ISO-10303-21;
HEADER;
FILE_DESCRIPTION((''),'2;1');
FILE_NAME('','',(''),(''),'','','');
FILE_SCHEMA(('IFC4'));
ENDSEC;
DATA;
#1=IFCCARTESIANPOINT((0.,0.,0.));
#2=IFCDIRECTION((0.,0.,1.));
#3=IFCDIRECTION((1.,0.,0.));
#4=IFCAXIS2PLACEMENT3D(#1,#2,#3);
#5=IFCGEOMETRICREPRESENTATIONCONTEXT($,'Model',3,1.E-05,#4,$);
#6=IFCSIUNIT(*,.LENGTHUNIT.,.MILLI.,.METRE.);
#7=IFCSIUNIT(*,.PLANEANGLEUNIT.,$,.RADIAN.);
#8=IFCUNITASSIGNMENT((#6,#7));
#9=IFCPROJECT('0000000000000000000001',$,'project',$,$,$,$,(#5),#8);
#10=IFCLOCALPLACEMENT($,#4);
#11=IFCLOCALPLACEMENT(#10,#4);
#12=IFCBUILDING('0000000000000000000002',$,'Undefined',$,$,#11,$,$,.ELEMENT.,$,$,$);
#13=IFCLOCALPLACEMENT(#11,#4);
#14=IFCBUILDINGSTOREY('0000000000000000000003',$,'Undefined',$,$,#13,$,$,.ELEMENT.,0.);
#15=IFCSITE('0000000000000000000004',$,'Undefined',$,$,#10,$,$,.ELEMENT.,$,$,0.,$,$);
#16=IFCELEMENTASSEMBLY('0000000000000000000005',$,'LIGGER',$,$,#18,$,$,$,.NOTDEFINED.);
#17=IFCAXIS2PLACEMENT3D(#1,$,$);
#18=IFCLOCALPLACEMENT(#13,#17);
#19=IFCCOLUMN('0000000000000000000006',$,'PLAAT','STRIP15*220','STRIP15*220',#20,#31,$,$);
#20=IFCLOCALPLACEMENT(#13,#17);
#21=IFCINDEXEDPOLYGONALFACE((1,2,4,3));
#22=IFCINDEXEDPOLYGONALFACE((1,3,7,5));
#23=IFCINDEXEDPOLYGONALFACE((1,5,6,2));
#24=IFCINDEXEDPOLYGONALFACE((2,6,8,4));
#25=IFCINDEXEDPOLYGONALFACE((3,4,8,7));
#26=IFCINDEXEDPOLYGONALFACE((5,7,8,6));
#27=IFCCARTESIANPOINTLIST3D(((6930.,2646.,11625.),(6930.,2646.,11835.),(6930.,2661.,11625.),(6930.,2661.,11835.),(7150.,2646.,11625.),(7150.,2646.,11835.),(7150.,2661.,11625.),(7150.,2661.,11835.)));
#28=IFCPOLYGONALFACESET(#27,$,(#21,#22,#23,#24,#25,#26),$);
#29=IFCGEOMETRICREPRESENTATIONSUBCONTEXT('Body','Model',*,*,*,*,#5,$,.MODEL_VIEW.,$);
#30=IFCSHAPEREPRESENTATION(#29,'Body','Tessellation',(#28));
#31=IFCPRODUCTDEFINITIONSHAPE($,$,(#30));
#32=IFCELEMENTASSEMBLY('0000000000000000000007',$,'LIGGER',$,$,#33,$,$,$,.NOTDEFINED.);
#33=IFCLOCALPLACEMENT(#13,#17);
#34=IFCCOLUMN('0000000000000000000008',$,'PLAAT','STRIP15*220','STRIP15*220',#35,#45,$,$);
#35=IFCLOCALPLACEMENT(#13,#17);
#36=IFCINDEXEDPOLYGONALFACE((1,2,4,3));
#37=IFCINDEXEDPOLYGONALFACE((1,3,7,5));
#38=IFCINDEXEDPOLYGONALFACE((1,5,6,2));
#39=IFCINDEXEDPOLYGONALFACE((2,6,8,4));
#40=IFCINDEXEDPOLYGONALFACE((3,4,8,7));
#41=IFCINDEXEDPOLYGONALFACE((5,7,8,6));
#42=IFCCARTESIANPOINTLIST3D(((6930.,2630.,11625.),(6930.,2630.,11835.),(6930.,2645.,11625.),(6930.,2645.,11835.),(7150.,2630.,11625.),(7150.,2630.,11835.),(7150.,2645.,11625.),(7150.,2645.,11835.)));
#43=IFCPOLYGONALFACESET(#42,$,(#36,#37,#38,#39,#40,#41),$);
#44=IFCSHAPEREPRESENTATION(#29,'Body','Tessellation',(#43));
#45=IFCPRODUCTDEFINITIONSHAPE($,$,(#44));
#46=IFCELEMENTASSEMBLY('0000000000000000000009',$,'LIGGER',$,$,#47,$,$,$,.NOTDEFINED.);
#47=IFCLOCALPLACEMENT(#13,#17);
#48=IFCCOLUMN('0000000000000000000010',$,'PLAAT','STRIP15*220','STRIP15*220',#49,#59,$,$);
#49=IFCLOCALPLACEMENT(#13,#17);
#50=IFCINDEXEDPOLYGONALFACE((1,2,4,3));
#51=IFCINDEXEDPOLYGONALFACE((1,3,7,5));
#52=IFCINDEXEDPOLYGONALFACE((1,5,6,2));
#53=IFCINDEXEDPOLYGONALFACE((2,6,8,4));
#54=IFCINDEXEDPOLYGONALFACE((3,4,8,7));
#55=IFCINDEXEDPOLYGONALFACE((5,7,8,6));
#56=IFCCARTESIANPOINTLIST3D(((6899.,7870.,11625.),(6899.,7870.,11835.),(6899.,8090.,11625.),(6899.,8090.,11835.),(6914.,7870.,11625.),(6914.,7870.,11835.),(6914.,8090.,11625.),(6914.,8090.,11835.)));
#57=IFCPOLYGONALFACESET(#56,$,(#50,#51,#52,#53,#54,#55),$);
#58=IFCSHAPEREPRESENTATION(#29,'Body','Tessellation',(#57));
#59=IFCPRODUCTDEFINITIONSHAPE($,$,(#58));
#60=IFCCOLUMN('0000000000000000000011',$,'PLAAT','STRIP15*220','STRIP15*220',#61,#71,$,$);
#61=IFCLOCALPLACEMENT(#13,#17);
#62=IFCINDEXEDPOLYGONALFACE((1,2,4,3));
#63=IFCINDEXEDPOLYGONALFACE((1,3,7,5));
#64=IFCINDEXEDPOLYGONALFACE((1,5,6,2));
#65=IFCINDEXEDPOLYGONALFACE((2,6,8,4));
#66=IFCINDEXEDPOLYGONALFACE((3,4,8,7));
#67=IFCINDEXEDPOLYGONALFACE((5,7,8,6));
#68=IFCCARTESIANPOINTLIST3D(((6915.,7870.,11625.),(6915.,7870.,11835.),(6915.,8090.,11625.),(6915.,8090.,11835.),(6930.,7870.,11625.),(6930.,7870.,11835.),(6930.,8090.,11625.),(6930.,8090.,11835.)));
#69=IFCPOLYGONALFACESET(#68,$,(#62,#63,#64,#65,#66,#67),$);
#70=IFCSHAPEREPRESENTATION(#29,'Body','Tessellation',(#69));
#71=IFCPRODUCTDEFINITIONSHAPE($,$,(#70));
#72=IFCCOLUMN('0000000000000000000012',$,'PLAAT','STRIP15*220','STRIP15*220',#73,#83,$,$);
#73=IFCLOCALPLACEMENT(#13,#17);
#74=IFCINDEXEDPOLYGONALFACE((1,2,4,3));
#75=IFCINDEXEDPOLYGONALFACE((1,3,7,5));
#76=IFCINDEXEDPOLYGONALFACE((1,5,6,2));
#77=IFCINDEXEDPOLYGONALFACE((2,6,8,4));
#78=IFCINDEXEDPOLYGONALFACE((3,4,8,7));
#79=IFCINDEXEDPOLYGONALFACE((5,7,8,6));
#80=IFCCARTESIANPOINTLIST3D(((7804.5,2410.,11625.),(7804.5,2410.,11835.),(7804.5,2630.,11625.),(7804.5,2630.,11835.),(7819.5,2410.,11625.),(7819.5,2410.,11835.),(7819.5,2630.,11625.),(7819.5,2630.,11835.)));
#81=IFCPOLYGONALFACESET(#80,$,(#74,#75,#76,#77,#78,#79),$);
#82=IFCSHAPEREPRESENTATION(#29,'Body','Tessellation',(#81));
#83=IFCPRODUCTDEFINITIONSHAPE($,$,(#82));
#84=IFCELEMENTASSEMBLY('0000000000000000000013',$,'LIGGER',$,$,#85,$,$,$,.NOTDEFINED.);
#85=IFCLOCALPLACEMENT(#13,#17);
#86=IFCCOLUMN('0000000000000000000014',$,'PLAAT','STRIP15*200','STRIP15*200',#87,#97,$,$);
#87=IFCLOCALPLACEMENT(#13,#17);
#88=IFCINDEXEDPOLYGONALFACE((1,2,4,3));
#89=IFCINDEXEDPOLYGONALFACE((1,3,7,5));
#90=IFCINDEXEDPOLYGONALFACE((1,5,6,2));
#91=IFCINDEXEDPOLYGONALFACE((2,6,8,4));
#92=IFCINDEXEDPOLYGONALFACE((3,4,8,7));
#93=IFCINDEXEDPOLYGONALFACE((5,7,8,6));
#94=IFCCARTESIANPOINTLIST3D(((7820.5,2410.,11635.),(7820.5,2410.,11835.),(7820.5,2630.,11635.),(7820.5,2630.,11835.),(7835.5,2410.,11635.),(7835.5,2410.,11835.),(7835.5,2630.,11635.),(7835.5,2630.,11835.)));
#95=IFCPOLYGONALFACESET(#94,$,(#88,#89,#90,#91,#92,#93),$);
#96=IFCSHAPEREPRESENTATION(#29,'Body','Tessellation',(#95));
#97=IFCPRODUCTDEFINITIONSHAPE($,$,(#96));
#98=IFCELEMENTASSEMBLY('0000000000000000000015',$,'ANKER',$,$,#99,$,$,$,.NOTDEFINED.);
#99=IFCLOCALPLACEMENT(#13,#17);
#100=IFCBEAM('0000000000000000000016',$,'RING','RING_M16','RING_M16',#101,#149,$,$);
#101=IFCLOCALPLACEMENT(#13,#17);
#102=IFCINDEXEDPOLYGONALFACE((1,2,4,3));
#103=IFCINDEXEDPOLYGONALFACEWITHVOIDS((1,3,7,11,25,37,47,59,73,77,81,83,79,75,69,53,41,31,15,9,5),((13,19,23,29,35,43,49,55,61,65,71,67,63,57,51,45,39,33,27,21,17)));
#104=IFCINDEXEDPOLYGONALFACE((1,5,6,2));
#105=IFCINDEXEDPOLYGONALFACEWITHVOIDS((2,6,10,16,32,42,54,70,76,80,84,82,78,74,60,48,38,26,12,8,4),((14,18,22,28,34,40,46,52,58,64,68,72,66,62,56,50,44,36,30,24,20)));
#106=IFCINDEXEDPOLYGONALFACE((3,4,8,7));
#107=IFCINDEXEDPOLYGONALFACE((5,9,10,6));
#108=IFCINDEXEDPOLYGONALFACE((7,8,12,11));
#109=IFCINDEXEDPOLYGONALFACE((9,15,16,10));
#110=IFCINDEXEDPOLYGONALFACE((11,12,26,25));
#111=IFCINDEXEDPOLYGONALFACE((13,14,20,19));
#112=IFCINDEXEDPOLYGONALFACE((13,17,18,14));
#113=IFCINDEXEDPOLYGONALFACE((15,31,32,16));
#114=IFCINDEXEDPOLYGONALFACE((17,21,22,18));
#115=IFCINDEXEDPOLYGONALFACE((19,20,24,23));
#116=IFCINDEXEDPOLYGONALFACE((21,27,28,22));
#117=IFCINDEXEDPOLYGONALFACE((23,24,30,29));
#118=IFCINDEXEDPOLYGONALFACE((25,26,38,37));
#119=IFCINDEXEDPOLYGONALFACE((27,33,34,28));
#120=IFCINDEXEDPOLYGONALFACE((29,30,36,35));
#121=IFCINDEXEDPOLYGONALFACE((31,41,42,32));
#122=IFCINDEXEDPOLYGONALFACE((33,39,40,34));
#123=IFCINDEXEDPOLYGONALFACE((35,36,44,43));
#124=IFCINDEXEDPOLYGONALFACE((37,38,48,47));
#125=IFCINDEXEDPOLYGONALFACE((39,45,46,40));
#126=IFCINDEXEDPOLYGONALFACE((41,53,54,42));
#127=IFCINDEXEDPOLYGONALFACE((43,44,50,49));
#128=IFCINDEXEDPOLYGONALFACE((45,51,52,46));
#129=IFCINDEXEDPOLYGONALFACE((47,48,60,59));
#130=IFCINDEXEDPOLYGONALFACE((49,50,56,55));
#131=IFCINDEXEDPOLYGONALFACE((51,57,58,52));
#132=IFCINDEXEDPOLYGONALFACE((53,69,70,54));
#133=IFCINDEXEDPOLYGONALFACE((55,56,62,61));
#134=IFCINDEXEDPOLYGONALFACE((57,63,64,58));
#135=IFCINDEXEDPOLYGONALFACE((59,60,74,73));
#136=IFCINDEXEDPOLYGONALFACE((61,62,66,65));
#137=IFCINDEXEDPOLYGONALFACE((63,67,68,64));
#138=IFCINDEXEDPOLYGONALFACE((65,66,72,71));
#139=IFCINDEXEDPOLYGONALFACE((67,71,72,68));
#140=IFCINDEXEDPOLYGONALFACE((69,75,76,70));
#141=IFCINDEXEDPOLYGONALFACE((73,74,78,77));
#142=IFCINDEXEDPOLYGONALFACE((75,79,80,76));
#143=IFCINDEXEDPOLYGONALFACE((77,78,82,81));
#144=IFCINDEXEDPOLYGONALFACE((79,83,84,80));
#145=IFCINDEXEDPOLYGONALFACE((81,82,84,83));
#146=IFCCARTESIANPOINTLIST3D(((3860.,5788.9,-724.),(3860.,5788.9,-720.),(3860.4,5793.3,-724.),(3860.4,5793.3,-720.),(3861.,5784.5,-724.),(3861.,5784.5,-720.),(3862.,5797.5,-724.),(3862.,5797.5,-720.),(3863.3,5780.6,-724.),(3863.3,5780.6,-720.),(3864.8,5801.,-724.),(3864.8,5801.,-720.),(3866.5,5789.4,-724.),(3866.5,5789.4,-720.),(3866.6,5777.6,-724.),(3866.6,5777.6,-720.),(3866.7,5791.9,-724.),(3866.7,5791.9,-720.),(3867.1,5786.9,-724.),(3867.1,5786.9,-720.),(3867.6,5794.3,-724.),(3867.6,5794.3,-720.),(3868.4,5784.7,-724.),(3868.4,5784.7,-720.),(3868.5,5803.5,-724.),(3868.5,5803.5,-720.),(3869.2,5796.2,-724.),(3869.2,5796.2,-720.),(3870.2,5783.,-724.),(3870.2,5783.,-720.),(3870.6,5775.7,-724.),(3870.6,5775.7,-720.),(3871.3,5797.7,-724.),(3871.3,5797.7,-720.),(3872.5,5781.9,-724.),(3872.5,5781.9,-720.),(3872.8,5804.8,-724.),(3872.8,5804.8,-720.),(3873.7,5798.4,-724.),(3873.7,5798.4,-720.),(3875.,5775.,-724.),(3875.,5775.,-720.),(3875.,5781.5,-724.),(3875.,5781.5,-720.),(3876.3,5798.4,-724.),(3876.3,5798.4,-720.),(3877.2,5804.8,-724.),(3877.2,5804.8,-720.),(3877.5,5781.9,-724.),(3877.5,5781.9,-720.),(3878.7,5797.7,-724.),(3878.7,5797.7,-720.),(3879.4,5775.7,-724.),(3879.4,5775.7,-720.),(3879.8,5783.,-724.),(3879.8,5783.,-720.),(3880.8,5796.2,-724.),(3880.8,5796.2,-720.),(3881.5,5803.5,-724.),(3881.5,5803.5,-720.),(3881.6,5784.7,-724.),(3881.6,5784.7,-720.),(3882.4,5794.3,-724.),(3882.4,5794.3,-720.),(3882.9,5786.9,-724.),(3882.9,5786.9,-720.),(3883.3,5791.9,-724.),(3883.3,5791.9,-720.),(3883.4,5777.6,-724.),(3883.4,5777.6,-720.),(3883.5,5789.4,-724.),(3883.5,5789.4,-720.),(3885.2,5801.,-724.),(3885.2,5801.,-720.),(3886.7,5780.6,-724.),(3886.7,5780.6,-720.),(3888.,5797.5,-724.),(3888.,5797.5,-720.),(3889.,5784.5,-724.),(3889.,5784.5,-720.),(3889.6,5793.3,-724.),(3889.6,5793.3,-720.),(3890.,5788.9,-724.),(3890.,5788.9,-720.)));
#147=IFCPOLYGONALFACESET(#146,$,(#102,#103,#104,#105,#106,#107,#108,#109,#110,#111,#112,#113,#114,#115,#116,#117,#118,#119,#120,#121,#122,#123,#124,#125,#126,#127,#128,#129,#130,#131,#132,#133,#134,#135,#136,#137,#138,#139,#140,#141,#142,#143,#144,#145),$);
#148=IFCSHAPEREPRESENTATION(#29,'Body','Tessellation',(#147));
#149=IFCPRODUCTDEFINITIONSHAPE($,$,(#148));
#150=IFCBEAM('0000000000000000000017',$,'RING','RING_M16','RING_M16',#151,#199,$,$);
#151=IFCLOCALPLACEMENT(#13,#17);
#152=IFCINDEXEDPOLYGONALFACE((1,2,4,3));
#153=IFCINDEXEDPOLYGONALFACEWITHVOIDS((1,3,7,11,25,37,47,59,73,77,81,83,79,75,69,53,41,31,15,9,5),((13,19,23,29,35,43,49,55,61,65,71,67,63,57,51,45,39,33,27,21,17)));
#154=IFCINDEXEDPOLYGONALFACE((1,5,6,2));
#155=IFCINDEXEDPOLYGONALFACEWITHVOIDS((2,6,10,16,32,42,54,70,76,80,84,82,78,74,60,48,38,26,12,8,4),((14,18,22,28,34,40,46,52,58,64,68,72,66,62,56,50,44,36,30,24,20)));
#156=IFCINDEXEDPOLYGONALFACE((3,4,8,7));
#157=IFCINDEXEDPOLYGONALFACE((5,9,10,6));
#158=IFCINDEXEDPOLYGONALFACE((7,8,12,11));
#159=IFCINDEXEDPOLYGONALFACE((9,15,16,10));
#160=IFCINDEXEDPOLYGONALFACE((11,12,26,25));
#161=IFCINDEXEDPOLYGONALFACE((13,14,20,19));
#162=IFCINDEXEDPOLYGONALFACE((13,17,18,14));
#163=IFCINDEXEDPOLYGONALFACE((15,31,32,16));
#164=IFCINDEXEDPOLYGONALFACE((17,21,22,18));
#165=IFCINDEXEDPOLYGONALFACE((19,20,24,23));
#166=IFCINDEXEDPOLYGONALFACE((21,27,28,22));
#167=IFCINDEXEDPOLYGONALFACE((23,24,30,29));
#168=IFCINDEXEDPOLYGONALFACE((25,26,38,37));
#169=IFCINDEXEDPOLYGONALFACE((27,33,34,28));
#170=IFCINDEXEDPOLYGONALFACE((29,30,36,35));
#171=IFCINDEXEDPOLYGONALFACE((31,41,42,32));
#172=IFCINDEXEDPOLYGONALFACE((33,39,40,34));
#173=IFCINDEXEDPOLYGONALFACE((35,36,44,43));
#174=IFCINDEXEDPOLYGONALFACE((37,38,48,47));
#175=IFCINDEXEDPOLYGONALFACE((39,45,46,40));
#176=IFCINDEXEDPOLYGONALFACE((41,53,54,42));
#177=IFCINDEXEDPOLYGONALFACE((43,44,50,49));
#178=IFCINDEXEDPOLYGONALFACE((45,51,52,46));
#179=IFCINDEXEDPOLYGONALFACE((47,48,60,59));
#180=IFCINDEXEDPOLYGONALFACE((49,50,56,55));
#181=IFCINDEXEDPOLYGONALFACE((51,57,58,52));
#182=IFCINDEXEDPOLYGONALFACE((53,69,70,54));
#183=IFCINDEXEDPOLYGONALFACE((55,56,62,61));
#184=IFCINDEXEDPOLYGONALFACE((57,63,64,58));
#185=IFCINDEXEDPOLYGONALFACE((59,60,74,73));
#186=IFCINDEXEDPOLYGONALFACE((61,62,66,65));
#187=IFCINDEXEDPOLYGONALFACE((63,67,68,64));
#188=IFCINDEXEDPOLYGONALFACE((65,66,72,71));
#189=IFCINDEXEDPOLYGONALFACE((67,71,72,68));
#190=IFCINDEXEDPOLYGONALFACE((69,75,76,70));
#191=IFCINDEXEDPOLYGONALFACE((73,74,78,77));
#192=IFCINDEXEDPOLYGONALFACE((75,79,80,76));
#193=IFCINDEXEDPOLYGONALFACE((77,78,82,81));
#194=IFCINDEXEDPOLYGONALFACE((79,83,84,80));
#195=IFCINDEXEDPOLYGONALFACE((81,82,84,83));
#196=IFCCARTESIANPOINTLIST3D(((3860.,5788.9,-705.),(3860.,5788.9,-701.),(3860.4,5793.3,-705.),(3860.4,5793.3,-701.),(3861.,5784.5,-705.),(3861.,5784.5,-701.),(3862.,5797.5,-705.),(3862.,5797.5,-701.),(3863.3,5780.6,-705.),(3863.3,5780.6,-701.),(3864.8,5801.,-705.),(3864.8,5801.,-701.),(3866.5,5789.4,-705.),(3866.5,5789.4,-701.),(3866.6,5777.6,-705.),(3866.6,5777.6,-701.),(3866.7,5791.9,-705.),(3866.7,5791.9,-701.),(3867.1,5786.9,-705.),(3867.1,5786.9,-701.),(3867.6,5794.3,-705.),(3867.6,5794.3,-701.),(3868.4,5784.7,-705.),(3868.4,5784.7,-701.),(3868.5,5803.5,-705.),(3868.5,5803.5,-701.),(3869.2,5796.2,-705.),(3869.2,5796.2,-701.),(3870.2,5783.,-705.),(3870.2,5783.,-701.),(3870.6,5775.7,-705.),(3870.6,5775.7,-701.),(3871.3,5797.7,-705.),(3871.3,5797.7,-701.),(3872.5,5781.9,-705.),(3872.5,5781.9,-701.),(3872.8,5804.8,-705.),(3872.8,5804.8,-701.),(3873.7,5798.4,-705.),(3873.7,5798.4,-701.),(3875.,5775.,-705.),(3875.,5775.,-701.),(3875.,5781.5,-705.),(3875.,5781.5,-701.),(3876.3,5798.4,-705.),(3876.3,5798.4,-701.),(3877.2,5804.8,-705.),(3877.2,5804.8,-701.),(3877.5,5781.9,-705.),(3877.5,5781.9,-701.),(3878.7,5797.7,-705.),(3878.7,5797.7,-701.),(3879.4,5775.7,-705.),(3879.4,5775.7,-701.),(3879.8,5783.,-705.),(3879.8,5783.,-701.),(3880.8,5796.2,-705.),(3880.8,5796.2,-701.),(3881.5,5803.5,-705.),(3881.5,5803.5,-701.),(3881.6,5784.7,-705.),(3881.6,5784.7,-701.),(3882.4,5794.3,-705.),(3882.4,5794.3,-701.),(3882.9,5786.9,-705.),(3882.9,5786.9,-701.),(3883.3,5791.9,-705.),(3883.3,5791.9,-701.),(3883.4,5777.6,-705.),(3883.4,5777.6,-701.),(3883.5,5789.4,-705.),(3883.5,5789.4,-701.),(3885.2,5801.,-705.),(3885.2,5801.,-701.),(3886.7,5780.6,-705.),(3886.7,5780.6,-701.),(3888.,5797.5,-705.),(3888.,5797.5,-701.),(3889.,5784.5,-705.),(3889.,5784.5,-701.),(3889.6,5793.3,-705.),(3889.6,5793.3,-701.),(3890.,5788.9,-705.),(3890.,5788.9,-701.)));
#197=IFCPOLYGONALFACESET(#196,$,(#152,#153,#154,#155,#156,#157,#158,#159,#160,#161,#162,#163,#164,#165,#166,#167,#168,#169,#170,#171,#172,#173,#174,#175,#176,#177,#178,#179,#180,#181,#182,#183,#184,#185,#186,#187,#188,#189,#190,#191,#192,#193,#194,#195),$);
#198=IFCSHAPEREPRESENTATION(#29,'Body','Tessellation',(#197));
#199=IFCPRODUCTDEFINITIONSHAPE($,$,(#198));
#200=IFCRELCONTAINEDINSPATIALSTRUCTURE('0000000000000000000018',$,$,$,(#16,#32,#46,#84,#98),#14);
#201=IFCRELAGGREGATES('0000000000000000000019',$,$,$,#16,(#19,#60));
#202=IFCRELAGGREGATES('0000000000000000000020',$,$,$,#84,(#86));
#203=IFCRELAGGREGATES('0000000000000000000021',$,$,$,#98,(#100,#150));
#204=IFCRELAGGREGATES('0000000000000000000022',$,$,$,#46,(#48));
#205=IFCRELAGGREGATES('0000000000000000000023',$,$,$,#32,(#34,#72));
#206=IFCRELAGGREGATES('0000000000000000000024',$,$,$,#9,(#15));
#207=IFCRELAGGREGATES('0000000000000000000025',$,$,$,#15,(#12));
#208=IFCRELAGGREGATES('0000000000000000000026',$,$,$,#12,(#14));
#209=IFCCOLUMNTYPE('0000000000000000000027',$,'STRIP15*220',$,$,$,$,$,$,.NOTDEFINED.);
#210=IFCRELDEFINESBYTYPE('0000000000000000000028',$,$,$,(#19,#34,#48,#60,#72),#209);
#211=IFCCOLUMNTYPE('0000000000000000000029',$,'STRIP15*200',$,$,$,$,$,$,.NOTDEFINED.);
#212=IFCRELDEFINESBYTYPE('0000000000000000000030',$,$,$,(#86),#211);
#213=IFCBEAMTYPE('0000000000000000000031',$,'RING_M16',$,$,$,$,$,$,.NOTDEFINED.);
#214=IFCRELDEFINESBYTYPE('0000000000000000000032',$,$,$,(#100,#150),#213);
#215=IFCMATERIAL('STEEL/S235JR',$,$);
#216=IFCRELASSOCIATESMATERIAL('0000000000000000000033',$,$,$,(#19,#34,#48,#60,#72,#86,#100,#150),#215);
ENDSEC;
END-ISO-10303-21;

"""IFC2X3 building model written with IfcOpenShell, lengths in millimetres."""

from ifc_helpers import new_model, si_unit, frame, origin_with_axes, origin_2d_with_axis, place, context, subcontext, project, spatial, rectangle, hollow_circle, extrude, material, type_object, element, aggregate, save


model = new_model("IFC2X3")

# Units and contexts
model_context = context("Model", 3, precision=1e-05, world=origin_with_axes())
body_context = subcontext(model_context, "Body", "Model", "MODEL_VIEW")
ifc_project = project(units=[si_unit("LENGTHUNIT", "METRE", prefix="MILLI"), si_unit("PLANEANGLEUNIT", "RADIAN")], contexts=[model_context])

# Site, building, storey
site_placement = place(None, origin_with_axes())
site = spatial("IfcSite", under=ifc_project, at=site_placement, Name="Undefined", CompositionType="ELEMENT", RefElevation=0.0)
building_placement = place(site_placement, origin_with_axes())
building = spatial("IfcBuilding", under=site, at=building_placement, Name="Undefined", CompositionType="ELEMENT")
storey_placement = place(building_placement, origin_with_axes())
storey = spatial("IfcBuildingStorey", under=building, at=storey_placement, Name="Undefined", CompositionType="ELEMENT", Elevation=0.0)

# Element assemblies, columns
assembly_1_placement = place(storey_placement, frame((7040.0, 14090.0, 11730.0), z_axis=(0.0, 0.0, 1.0), x_axis=(0.0, -1.0, 0.0)))
assembly_1 = element("IfcElementAssembly", 1, at=assembly_1_placement, inside=storey, Name="LIGGER", PredefinedType="NOTDEFINED")
ifc_material = material(Name="STEEL/S235JR")
column_type_1 = type_object("IfcColumnType", Name="STRIP15*220", PredefinedType="NOTDEFINED")
column_1_placement = place(storey_placement, frame((7040.0, 2653.5, 11625.0), z_axis=(0.0, 0.0, 1.0), x_axis=(1.0, 0.0, 0.0)))
column_1 = element("IfcColumn", 2, at=column_1_placement, type_object=column_type_1, material=ifc_material, Name="PLAAT", Description="STRIP15*220", ObjectType="STRIP15*220", context=body_context, shape_type="SweptSolid", body=[
    extrude(rectangle(XDim=15.0, YDim=220.0, at=origin_2d_with_axis()), frame((0.0, 0.0, 210.0), z_axis=(0.0, 0.0, -1.0), x_axis=(0.0, 1.0, 0.0)), (0.0, 0.0, 1.0), 210.0),
])
assembly_2_placement = place(storey_placement, frame((5568.2, 2520.0, 9192.5), z_axis=(-0.906308, 0.0, 0.422618), x_axis=(0.422618, 0.0, 0.906308)))
assembly_2 = element("IfcElementAssembly", 3, at=assembly_2_placement, inside=storey, Name="LIGGER", PredefinedType="NOTDEFINED")
column_2_placement = place(storey_placement, frame((7040.0, 2637.5, 11625.0), z_axis=(0.0, 0.0, 1.0), x_axis=(1.0, 0.0, 0.0)))
column_2 = element("IfcColumn", 4, at=column_2_placement, type_object=column_type_1, material=ifc_material, Name="PLAAT", Description="STRIP15*220", ObjectType="STRIP15*220", context=body_context, shape_type="SweptSolid", body=[
    extrude(rectangle(XDim=15.0, YDim=220.0, at=origin_2d_with_axis()), frame((0.0, 0.0, 210.0), z_axis=(0.0, 0.0, -1.0), x_axis=(0.0, 1.0, 0.0)), (0.0, 0.0, 1.0), 210.0),
])
assembly_3_placement = place(storey_placement, frame((5568.2, 7980.0, 9192.5), z_axis=(-0.906308, 0.0, 0.422618), x_axis=(0.422618, 0.0, 0.906308)))
assembly_3 = element("IfcElementAssembly", 5, at=assembly_3_placement, inside=storey, Name="LIGGER", PredefinedType="NOTDEFINED")
column_3_placement = place(storey_placement, frame((6906.5, 7980.0, 11625.0), z_axis=(0.0, 0.0, 1.0), x_axis=(1.0, 0.0, 0.0)))
column_3 = element("IfcColumn", 6, at=column_3_placement, type_object=column_type_1, material=ifc_material, Name="PLAAT", Description="STRIP15*220", ObjectType="STRIP15*220", context=body_context, shape_type="SweptSolid", body=[
    extrude(rectangle(XDim=15.0, YDim=220.0, at=origin_2d_with_axis()), frame((0.0, 0.0, 210.0), z_axis=(0.0, 0.0, -1.0), x_axis=(-1.0, 0.0, 0.0)), (0.0, 0.0, 1.0), 210.0),
])

# Columns
column_4_placement = place(storey_placement, frame((6922.5, 7980.0, 11625.0), z_axis=(0.0, 0.0, 1.0), x_axis=(1.0, 0.0, 0.0)))
column_4 = element("IfcColumn", 7, at=column_4_placement, type_object=column_type_1, material=ifc_material, Name="PLAAT", Description="STRIP15*220", ObjectType="STRIP15*220", context=body_context, shape_type="SweptSolid", body=[
    extrude(rectangle(XDim=15.0, YDim=220.0, at=origin_2d_with_axis()), frame((0.0, 0.0, 210.0), z_axis=(0.0, 0.0, -1.0), x_axis=(-1.0, 0.0, 0.0)), (0.0, 0.0, 1.0), 210.0),
])
aggregate(assembly_1, [column_1, column_4])
column_5_placement = place(storey_placement, frame((7812.0, 2520.0, 11625.0), z_axis=(0.0, 0.0, 1.0), x_axis=(1.0, 0.0, 0.0)))
column_5 = element("IfcColumn", 8, at=column_5_placement, type_object=column_type_1, material=ifc_material, Name="PLAAT", Description="STRIP15*220", ObjectType="STRIP15*220", context=body_context, shape_type="SweptSolid", body=[
    extrude(rectangle(XDim=15.0, YDim=220.0, at=origin_2d_with_axis()), frame((0.0, 0.0, 210.0), z_axis=(0.0, 0.0, -1.0), x_axis=(1.0, 0.0, 0.0)), (0.0, 0.0, 1.0), 210.0),
])

# Element assembly, column
assembly_4_placement = place(storey_placement, frame((7820.0, 2520.0, 11735.0), z_axis=(0.0, 0.0, 1.0), x_axis=(1.0, 0.0, 0.0)))
assembly_4 = element("IfcElementAssembly", 9, at=assembly_4_placement, inside=storey, Name="LIGGER", PredefinedType="NOTDEFINED")
column_type_2 = type_object("IfcColumnType", Name="STRIP15*200", PredefinedType="NOTDEFINED")
column_6_placement = place(storey_placement, frame((7828.0, 2520.0, 11635.0), z_axis=(0.0, 0.0, 1.0), x_axis=(1.0, 0.0, 0.0)))
column_6 = element("IfcColumn", 10, at=column_6_placement, type_object=column_type_2, material=ifc_material, Name="PLAAT", Description="STRIP15*200", ObjectType="STRIP15*200", context=body_context, shape_type="SweptSolid", body=[
    extrude(rectangle(XDim=15.0, YDim=220.0, at=origin_2d_with_axis()), frame((0.0, 0.0, 200.0), z_axis=(0.0, 0.0, -1.0), x_axis=(1.0, 0.0, 0.0)), (0.0, 0.0, 1.0), 200.0),
])
aggregate(assembly_4, [column_6])

# Element assembly, beams
assembly_5_placement = place(storey_placement, frame((3875.0, 5790.0, -655.0), z_axis=(1.0, 0.0, 0.0), x_axis=(0.0, 0.0, -1.0)))
assembly_5 = element("IfcElementAssembly", 11, at=assembly_5_placement, inside=storey, Name="ANKER", PredefinedType="NOTDEFINED")
beam_type_1 = type_object("IfcBeamType", Name="RING_M16", PredefinedType="NOTDEFINED")
beam_1_placement = place(storey_placement, frame((3875.0, 5790.0, -720.0), z_axis=(1.0, 0.0, 0.0), x_axis=(0.0, 0.0, -1.0)))
beam_1 = element("IfcBeam", 12, at=beam_1_placement, type_object=beam_type_1, material=ifc_material, Name="RING", Description="RING_M16", ObjectType="RING_M16", context=body_context, shape_type="SweptSolid", body=[
    extrude(hollow_circle(Radius=15.0, WallThickness=6.5, at=origin_2d_with_axis()), frame((4.0, 0.0, 0.0), z_axis=(-1.0, 0.0, 0.0), x_axis=(0.0, -1.0, 0.0)), (0.0, 0.0, 1.0), 4.0),
])
beam_2_placement = place(storey_placement, frame((3875.0, 5790.0, -701.0), z_axis=(1.0, 0.0, 0.0), x_axis=(0.0, 0.0, -1.0)))
beam_2 = element("IfcBeam", 13, at=beam_2_placement, type_object=beam_type_1, material=ifc_material, Name="RING", Description="RING_M16", ObjectType="RING_M16", context=body_context, shape_type="SweptSolid", body=[
    extrude(hollow_circle(Radius=15.0, WallThickness=6.5, at=origin_2d_with_axis()), frame((4.0, 0.0, 0.0), z_axis=(-1.0, 0.0, 0.0), x_axis=(0.0, -1.0, 0.0)), (0.0, 0.0, 1.0), 4.0),
])
aggregate(assembly_5, [beam_1, beam_2])

aggregate(assembly_3, [column_3])
aggregate(assembly_2, [column_2, column_5])

save(model, "model.ifc")
